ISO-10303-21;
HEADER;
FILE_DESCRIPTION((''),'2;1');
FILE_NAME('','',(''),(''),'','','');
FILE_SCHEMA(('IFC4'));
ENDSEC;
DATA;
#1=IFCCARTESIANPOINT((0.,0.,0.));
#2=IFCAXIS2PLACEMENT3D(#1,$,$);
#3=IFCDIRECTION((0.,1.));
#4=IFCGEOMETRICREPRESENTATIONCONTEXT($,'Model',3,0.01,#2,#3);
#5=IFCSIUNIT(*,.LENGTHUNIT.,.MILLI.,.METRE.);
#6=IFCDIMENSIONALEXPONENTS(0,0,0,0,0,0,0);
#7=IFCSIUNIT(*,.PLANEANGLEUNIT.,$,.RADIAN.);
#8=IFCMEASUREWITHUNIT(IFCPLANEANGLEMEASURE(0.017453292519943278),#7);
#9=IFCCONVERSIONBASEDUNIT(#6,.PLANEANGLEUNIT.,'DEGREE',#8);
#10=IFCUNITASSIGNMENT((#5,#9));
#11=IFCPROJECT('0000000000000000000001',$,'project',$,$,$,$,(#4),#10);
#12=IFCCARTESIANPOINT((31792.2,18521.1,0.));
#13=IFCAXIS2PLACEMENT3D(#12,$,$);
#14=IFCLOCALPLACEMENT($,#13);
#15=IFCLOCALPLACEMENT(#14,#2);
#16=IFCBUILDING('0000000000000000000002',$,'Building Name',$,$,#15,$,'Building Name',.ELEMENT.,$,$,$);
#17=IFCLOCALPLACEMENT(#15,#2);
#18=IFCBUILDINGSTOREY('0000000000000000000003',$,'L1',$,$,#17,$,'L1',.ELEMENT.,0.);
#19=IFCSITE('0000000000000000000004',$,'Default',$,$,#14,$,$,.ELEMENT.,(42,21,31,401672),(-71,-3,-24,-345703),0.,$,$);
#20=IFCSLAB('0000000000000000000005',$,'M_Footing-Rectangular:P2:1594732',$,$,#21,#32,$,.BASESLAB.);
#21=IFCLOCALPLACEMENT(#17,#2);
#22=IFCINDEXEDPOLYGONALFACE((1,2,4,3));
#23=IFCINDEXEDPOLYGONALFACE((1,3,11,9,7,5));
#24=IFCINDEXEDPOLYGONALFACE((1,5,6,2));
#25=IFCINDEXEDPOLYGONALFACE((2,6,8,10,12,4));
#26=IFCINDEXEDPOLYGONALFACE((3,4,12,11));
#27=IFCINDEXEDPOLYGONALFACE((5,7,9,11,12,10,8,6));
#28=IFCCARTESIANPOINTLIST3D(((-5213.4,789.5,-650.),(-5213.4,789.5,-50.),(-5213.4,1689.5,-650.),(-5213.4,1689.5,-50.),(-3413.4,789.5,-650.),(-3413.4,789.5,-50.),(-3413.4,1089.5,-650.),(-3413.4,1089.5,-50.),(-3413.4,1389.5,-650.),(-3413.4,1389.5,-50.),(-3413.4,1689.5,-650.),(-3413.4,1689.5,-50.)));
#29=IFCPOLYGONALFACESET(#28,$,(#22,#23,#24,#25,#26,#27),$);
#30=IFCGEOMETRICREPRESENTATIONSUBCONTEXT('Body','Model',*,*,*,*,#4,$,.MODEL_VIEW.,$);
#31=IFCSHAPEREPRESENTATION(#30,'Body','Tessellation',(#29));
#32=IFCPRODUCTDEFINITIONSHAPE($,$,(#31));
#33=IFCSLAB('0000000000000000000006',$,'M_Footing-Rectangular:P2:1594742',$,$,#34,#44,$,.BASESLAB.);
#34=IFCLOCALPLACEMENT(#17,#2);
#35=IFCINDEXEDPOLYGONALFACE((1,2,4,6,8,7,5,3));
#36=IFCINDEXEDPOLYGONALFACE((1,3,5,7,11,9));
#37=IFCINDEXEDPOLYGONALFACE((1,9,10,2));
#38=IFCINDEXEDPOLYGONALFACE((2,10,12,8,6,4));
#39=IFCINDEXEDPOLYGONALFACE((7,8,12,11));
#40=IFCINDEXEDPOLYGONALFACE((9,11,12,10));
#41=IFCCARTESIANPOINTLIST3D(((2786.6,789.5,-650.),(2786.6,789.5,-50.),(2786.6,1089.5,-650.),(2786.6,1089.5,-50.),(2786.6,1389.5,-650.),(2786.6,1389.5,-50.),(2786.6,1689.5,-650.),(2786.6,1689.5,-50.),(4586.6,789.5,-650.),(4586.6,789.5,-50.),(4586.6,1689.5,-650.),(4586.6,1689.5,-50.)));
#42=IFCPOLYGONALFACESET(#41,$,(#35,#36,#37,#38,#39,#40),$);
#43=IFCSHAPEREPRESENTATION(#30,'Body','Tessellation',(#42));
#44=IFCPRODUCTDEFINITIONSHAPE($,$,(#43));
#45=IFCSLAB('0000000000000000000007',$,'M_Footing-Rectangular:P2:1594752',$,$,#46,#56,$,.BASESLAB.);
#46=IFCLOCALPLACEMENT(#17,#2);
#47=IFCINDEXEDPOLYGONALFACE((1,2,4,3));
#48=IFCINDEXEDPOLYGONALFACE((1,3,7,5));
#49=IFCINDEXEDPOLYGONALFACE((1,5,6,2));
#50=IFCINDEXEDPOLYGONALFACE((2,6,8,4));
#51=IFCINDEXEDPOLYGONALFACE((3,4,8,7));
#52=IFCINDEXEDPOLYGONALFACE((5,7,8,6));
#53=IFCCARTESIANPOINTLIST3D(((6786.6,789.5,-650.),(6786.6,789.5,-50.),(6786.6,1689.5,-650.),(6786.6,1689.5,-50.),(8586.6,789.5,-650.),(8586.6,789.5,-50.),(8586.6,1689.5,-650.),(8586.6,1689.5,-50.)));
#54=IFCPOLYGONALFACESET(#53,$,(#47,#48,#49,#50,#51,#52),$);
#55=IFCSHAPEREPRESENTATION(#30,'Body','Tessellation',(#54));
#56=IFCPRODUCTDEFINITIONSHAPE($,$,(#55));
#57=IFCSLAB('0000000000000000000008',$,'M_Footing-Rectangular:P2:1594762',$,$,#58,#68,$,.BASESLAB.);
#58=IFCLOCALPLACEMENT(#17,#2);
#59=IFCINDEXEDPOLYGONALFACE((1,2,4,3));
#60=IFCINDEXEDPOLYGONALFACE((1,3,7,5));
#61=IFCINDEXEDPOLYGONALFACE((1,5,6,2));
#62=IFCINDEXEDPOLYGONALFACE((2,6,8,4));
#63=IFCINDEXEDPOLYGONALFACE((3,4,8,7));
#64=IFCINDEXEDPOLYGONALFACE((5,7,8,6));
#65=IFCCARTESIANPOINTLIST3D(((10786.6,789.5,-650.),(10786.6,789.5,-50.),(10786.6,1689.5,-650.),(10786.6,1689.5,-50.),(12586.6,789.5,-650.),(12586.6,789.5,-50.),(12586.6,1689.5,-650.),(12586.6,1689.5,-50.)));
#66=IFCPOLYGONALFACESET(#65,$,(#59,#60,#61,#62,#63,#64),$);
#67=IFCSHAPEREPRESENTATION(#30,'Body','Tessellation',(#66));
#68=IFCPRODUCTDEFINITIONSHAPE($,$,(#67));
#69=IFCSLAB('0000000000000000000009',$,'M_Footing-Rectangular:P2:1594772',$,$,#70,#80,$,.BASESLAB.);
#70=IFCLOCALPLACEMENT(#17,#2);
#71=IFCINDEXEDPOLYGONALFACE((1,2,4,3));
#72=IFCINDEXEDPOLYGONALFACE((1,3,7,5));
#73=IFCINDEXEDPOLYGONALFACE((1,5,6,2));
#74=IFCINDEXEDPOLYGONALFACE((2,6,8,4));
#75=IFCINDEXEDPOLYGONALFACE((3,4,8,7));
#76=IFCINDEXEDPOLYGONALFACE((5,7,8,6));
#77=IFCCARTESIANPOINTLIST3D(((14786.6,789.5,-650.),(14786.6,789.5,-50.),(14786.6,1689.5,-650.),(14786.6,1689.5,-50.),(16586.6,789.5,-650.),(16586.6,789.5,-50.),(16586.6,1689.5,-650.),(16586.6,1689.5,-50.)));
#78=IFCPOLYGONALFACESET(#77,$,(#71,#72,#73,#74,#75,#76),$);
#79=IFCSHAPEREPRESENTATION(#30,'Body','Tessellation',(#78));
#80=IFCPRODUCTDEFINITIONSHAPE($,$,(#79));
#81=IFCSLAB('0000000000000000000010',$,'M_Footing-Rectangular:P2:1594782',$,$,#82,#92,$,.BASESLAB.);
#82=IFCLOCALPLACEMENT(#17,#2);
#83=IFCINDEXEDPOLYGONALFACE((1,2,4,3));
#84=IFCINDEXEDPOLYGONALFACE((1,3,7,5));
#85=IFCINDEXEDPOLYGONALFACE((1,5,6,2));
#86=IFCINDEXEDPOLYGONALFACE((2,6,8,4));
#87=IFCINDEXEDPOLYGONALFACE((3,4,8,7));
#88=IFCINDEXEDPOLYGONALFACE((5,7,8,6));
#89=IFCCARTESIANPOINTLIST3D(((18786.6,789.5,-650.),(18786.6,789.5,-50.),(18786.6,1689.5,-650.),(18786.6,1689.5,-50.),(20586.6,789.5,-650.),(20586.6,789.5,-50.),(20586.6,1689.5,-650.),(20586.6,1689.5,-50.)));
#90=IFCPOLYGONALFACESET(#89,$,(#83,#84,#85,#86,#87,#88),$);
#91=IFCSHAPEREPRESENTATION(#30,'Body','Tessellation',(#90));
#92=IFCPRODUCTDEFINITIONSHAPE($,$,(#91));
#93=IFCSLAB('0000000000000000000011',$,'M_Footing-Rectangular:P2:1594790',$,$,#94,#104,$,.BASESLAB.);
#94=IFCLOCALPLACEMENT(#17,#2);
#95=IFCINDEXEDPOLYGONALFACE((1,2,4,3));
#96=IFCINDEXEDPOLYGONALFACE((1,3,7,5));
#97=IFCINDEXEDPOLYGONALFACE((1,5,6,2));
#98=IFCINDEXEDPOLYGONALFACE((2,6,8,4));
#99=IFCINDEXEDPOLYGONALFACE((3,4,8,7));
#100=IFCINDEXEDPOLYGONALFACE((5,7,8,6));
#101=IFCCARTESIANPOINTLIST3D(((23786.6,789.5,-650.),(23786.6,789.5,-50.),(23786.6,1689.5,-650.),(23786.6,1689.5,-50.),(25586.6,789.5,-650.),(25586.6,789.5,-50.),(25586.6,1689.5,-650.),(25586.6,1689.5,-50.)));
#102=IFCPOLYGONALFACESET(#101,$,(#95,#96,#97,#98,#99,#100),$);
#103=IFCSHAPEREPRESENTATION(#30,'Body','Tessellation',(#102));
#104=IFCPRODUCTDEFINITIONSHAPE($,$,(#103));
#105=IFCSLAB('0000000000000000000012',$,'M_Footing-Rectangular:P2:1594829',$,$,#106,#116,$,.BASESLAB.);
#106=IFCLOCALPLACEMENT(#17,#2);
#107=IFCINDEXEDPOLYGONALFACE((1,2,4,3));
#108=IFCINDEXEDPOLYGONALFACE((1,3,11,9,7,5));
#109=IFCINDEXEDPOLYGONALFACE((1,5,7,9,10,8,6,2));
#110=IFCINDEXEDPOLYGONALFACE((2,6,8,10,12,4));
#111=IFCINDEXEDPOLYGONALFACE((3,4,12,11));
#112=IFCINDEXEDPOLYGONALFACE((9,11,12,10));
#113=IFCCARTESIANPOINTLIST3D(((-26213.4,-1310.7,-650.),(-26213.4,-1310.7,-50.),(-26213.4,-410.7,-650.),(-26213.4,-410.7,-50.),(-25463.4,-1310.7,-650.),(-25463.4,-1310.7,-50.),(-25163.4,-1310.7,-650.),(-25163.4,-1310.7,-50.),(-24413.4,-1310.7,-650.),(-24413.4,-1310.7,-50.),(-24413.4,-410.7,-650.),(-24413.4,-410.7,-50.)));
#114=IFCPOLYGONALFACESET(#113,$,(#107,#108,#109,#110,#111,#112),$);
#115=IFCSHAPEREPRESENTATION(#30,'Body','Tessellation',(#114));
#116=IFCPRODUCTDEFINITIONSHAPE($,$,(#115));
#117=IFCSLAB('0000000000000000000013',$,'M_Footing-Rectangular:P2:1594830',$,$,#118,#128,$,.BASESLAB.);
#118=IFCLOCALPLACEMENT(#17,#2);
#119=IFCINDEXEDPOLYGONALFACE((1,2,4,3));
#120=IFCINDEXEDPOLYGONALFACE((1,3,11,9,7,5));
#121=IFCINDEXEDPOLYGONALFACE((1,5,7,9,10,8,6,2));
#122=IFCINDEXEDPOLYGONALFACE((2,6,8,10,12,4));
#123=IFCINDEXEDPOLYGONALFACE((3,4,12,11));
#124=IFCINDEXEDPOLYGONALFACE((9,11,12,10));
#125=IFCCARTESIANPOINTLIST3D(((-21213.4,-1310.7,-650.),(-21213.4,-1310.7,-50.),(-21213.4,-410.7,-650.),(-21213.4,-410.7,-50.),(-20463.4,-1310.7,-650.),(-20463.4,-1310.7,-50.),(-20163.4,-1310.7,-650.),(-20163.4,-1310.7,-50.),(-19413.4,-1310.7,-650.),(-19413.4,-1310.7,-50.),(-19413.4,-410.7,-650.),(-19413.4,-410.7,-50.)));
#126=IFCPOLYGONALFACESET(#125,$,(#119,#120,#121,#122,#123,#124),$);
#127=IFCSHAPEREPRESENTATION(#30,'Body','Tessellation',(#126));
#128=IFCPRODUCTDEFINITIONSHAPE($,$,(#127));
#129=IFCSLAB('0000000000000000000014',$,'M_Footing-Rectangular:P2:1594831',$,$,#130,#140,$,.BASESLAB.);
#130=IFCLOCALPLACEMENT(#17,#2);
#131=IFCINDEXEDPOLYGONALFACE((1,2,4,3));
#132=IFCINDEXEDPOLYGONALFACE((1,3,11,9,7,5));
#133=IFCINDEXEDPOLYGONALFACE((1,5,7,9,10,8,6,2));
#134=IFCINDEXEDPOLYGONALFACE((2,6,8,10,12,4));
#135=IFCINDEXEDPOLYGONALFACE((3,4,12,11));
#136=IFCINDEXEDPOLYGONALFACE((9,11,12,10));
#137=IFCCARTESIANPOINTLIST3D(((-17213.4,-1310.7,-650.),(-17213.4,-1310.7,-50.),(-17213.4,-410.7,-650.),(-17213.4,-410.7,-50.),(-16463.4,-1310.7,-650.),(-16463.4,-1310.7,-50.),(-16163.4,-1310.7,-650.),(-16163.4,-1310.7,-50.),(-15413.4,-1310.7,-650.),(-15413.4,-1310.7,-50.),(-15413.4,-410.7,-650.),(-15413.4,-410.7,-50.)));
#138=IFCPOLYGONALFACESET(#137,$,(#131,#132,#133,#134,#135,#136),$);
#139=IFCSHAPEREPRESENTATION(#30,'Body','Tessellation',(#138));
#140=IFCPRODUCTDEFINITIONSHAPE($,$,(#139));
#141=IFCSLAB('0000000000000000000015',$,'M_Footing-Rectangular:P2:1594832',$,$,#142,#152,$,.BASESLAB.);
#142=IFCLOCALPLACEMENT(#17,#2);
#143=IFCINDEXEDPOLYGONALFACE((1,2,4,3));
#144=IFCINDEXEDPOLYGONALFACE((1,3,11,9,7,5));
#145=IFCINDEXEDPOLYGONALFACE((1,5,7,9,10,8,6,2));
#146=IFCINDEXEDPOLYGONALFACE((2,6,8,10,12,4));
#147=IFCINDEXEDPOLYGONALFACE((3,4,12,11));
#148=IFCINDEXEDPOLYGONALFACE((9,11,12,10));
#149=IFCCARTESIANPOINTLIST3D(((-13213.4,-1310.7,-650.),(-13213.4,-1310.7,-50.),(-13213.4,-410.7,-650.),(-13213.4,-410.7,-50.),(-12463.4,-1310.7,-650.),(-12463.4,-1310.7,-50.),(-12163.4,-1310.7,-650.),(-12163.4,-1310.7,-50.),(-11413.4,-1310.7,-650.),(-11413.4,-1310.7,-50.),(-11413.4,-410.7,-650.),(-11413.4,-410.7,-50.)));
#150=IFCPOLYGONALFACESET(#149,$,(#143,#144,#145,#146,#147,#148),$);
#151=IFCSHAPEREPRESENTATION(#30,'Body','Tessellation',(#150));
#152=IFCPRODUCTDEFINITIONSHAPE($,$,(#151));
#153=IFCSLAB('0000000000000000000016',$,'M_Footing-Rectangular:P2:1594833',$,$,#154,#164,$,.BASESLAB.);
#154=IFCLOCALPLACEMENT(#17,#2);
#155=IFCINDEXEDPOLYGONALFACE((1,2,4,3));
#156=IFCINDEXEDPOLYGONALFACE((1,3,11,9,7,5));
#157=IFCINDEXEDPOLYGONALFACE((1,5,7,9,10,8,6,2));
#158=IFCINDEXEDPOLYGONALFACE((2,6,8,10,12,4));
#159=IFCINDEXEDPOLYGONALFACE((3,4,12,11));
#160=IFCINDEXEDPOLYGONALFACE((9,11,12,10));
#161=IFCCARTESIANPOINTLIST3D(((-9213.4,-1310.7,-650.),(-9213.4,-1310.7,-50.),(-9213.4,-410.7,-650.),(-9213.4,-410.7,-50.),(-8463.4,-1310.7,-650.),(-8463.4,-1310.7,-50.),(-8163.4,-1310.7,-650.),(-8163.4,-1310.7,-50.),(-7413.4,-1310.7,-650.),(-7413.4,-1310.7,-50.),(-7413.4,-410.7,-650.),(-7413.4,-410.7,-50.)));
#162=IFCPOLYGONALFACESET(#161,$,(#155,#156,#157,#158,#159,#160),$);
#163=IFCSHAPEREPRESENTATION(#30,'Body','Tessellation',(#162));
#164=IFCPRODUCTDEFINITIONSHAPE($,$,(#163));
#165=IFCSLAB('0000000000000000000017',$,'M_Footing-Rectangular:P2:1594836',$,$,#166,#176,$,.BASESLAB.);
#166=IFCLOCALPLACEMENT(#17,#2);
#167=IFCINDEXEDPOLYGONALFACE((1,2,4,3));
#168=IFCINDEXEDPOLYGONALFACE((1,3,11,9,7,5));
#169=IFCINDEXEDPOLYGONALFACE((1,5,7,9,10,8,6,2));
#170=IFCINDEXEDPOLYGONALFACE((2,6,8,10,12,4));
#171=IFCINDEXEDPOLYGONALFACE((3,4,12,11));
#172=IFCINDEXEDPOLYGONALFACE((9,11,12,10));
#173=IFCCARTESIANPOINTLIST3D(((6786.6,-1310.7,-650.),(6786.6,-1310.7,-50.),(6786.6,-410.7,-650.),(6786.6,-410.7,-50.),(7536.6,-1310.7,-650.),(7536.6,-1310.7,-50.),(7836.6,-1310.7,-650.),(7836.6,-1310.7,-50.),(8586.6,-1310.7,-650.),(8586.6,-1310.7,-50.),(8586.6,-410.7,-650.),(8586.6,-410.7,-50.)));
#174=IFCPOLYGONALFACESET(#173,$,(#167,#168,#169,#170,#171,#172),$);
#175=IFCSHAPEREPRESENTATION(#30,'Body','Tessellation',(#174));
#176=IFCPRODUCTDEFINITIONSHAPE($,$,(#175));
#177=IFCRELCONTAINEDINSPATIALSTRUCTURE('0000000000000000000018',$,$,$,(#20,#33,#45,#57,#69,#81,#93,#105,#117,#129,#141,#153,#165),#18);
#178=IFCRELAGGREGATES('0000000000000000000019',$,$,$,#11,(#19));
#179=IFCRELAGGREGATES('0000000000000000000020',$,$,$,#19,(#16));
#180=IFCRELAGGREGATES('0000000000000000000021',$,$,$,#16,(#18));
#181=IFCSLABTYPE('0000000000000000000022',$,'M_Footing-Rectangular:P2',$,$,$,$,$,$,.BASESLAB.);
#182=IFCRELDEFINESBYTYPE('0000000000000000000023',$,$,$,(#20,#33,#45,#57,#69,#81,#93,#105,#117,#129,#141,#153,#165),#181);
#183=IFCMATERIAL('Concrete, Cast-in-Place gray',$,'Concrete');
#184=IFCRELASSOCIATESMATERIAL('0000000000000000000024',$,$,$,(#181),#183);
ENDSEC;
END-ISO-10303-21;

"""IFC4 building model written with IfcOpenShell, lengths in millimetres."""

from ifc_helpers import new_model, entity, si_unit, converted_unit, direction, frame, origin, place, context, subcontext, project, spatial, indexed_curve, outline, extrude, material, type_object, element, save


model = new_model("IFC4")

# Units and contexts
model_context = context("Model", 3, precision=0.01, world=origin(), true_north=direction((0.0, 1.0)))
body_context = subcontext(model_context, "Body", "Model", "MODEL_VIEW")
ifc_project = project(units=[si_unit("LENGTHUNIT", "METRE", prefix="MILLI"), converted_unit("PLANEANGLEUNIT", "DEGREE", entity("IfcPlaneAngleMeasure", 0.017453292519943278), si_unit("PLANEANGLEUNIT", "RADIAN"), dimensions=[0, 0, 0, 0, 0, 0, 0])], contexts=[model_context])

# Site, building, storey
site_placement = place(None, frame((31792.2, 18521.1, 0.0)))
site = spatial("IfcSite", under=ifc_project, at=site_placement, Name="Default", CompositionType="ELEMENT", RefLatitude=(42, 21, 31, 401672), RefLongitude=(-71, -3, -24, -345703), RefElevation=0.0)
building_placement = place(site_placement, origin())
building = spatial("IfcBuilding", under=site, at=building_placement, Name="Building Name", LongName="Building Name", CompositionType="ELEMENT")
storey_placement = place(building_placement, origin())
storey = spatial("IfcBuildingStorey", under=building, at=storey_placement, Name="L1", LongName="L1", CompositionType="ELEMENT", Elevation=0.0)

# Slabs
ifc_material = material(Name="Concrete, Cast-in-Place gray", Category="Concrete")
slab_type = type_object("IfcSlabType", Name="M_Footing-Rectangular:P2", PredefinedType="BASESLAB", material=ifc_material)
slab_1_placement = place(storey_placement, origin())
element("IfcSlab", 1, at=slab_1_placement, inside=storey, type_object=slab_type, Name="M_Footing-Rectangular:P2:1594732", PredefinedType="BASESLAB", context=body_context, shape_type="SweptSolid", body=[
    extrude(outline(indexed_curve([(-450.0, -1200.0), (450.0, -1200.0), (450.0, 600.0), (150.0, 600.0), (-150.0, 600.0), (-450.0, 600.0), (-450.0, -1200.0)], self_intersect=False)), frame((-4013.4, 1239.5, -650.0), z_axis=(0.0, 0.0, 1.0), x_axis=(0.0, -1.0, 0.0)), (0.0, 0.0, 1.0), 600.0),
])
slab_2_placement = place(storey_placement, origin())
element("IfcSlab", 2, at=slab_2_placement, inside=storey, type_object=slab_type, Name="M_Footing-Rectangular:P2:1594742", PredefinedType="BASESLAB", context=body_context, shape_type="SweptSolid", body=[
    extrude(outline(indexed_curve([(-450.0, -600.0), (-150.0, -600.0), (150.0, -600.0), (450.0, -600.0), (450.0, 1200.0), (-450.0, 1200.0), (-450.0, -600.0)], self_intersect=False)), frame((3386.6, 1239.5, -650.0), z_axis=(0.0, 0.0, 1.0), x_axis=(0.0, -1.0, 0.0)), (0.0, 0.0, 1.0), 600.0),
])
slab_3_placement = place(storey_placement, origin())
element("IfcSlab", 3, at=slab_3_placement, inside=storey, type_object=slab_type, Name="M_Footing-Rectangular:P2:1594752", PredefinedType="BASESLAB", context=body_context, shape_type="SweptSolid", body=[
    extrude(outline(indexed_curve([(-450.0, -900.0), (450.0, -900.0), (450.0, 900.0), (-450.0, 900.0), (-450.0, -900.0)], self_intersect=False)), frame((7686.6, 1239.5, -650.0), z_axis=(0.0, 0.0, 1.0), x_axis=(0.0, -1.0, 0.0)), (0.0, 0.0, 1.0), 600.0),
])
slab_4_placement = place(storey_placement, origin())
element("IfcSlab", 4, at=slab_4_placement, inside=storey, type_object=slab_type, Name="M_Footing-Rectangular:P2:1594762", PredefinedType="BASESLAB", context=body_context, shape_type="SweptSolid", body=[
    extrude(outline(indexed_curve([(-450.0, -900.0), (450.0, -900.0), (450.0, 900.0), (-450.0, 900.0), (-450.0, -900.0)], self_intersect=False)), frame((11686.6, 1239.5, -650.0), z_axis=(0.0, 0.0, 1.0), x_axis=(0.0, -1.0, 0.0)), (0.0, 0.0, 1.0), 600.0),
])
slab_5_placement = place(storey_placement, origin())
element("IfcSlab", 5, at=slab_5_placement, inside=storey, type_object=slab_type, Name="M_Footing-Rectangular:P2:1594772", PredefinedType="BASESLAB", context=body_context, shape_type="SweptSolid", body=[
    extrude(outline(indexed_curve([(-450.0, -900.0), (450.0, -900.0), (450.0, 900.0), (-450.0, 900.0), (-450.0, -900.0)], self_intersect=False)), frame((15686.6, 1239.5, -650.0), z_axis=(0.0, 0.0, 1.0), x_axis=(0.0, -1.0, 0.0)), (0.0, 0.0, 1.0), 600.0),
])
slab_6_placement = place(storey_placement, origin())
element("IfcSlab", 6, at=slab_6_placement, inside=storey, type_object=slab_type, Name="M_Footing-Rectangular:P2:1594782", PredefinedType="BASESLAB", context=body_context, shape_type="SweptSolid", body=[
    extrude(outline(indexed_curve([(-450.0, -900.0), (450.0, -900.0), (450.0, 900.0), (-450.0, 900.0), (-450.0, -900.0)], self_intersect=False)), frame((19686.6, 1239.5, -650.0), z_axis=(0.0, 0.0, 1.0), x_axis=(0.0, -1.0, 0.0)), (0.0, 0.0, 1.0), 600.0),
])
slab_7_placement = place(storey_placement, origin())
element("IfcSlab", 7, at=slab_7_placement, inside=storey, type_object=slab_type, Name="M_Footing-Rectangular:P2:1594790", PredefinedType="BASESLAB", context=body_context, shape_type="SweptSolid", body=[
    extrude(outline(indexed_curve([(-450.0, -900.0), (450.0, -900.0), (450.0, 900.0), (-450.0, 900.0), (-450.0, -900.0)], self_intersect=False)), frame((24686.6, 1239.5, -650.0), z_axis=(0.0, 0.0, 1.0), x_axis=(0.0, -1.0, 0.0)), (0.0, 0.0, 1.0), 600.0),
])
slab_8_placement = place(storey_placement, origin())
element("IfcSlab", 8, at=slab_8_placement, inside=storey, type_object=slab_type, Name="M_Footing-Rectangular:P2:1594829", PredefinedType="BASESLAB", context=body_context, shape_type="SweptSolid", body=[
    extrude(outline(indexed_curve([(-600.0, -900.0), (300.0, -900.0), (300.0, -150.0), (300.0, 150.0), (300.0, 900.0), (-600.0, 900.0), (-600.0, -900.0)], self_intersect=False)), frame((-25313.4, -1010.7, -650.0), z_axis=(0.0, 0.0, 1.0), x_axis=(0.0, -1.0, 0.0)), (0.0, 0.0, 1.0), 600.0),
])
slab_9_placement = place(storey_placement, origin())
element("IfcSlab", 9, at=slab_9_placement, inside=storey, type_object=slab_type, Name="M_Footing-Rectangular:P2:1594830", PredefinedType="BASESLAB", context=body_context, shape_type="SweptSolid", body=[
    extrude(outline(indexed_curve([(-600.0, -900.0), (300.0, -900.0), (300.0, -150.0), (300.0, 150.0), (300.0, 900.0), (-600.0, 900.0), (-600.0, -900.0)], self_intersect=False)), frame((-20313.4, -1010.7, -650.0), z_axis=(0.0, 0.0, 1.0), x_axis=(0.0, -1.0, 0.0)), (0.0, 0.0, 1.0), 600.0),
])
slab_10_placement = place(storey_placement, origin())
element("IfcSlab", 10, at=slab_10_placement, inside=storey, type_object=slab_type, Name="M_Footing-Rectangular:P2:1594831", PredefinedType="BASESLAB", context=body_context, shape_type="SweptSolid", body=[
    extrude(outline(indexed_curve([(-600.0, -900.0), (300.0, -900.0), (300.0, -150.0), (300.0, 150.0), (300.0, 900.0), (-600.0, 900.0), (-600.0, -900.0)], self_intersect=False)), frame((-16313.4, -1010.7, -650.0), z_axis=(0.0, 0.0, 1.0), x_axis=(0.0, -1.0, 0.0)), (0.0, 0.0, 1.0), 600.0),
])
slab_11_placement = place(storey_placement, origin())
element("IfcSlab", 11, at=slab_11_placement, inside=storey, type_object=slab_type, Name="M_Footing-Rectangular:P2:1594832", PredefinedType="BASESLAB", context=body_context, shape_type="SweptSolid", body=[
    extrude(outline(indexed_curve([(-600.0, -900.0), (300.0, -900.0), (300.0, -150.0), (300.0, 150.0), (300.0, 900.0), (-600.0, 900.0), (-600.0, -900.0)], self_intersect=False)), frame((-12313.4, -1010.7, -650.0), z_axis=(0.0, 0.0, 1.0), x_axis=(0.0, -1.0, 0.0)), (0.0, 0.0, 1.0), 600.0),
])
slab_12_placement = place(storey_placement, origin())
element("IfcSlab", 12, at=slab_12_placement, inside=storey, type_object=slab_type, Name="M_Footing-Rectangular:P2:1594833", PredefinedType="BASESLAB", context=body_context, shape_type="SweptSolid", body=[
    extrude(outline(indexed_curve([(-600.0, -900.0), (300.0, -900.0), (300.0, -150.0), (300.0, 150.0), (300.0, 900.0), (-600.0, 900.0), (-600.0, -900.0)], self_intersect=False)), frame((-8313.4, -1010.7, -650.0), z_axis=(0.0, 0.0, 1.0), x_axis=(0.0, -1.0, 0.0)), (0.0, 0.0, 1.0), 600.0),
])
slab_13_placement = place(storey_placement, origin())
element("IfcSlab", 13, at=slab_13_placement, inside=storey, type_object=slab_type, Name="M_Footing-Rectangular:P2:1594836", PredefinedType="BASESLAB", context=body_context, shape_type="SweptSolid", body=[
    extrude(outline(indexed_curve([(-600.0, -900.0), (300.0, -900.0), (300.0, -150.0), (300.0, 150.0), (300.0, 900.0), (-600.0, 900.0), (-600.0, -900.0)], self_intersect=False)), frame((7686.6, -1010.7, -650.0), z_axis=(0.0, 0.0, 1.0), x_axis=(0.0, -1.0, 0.0)), (0.0, 0.0, 1.0), 600.0),
])

save(model, "model.ifc")
